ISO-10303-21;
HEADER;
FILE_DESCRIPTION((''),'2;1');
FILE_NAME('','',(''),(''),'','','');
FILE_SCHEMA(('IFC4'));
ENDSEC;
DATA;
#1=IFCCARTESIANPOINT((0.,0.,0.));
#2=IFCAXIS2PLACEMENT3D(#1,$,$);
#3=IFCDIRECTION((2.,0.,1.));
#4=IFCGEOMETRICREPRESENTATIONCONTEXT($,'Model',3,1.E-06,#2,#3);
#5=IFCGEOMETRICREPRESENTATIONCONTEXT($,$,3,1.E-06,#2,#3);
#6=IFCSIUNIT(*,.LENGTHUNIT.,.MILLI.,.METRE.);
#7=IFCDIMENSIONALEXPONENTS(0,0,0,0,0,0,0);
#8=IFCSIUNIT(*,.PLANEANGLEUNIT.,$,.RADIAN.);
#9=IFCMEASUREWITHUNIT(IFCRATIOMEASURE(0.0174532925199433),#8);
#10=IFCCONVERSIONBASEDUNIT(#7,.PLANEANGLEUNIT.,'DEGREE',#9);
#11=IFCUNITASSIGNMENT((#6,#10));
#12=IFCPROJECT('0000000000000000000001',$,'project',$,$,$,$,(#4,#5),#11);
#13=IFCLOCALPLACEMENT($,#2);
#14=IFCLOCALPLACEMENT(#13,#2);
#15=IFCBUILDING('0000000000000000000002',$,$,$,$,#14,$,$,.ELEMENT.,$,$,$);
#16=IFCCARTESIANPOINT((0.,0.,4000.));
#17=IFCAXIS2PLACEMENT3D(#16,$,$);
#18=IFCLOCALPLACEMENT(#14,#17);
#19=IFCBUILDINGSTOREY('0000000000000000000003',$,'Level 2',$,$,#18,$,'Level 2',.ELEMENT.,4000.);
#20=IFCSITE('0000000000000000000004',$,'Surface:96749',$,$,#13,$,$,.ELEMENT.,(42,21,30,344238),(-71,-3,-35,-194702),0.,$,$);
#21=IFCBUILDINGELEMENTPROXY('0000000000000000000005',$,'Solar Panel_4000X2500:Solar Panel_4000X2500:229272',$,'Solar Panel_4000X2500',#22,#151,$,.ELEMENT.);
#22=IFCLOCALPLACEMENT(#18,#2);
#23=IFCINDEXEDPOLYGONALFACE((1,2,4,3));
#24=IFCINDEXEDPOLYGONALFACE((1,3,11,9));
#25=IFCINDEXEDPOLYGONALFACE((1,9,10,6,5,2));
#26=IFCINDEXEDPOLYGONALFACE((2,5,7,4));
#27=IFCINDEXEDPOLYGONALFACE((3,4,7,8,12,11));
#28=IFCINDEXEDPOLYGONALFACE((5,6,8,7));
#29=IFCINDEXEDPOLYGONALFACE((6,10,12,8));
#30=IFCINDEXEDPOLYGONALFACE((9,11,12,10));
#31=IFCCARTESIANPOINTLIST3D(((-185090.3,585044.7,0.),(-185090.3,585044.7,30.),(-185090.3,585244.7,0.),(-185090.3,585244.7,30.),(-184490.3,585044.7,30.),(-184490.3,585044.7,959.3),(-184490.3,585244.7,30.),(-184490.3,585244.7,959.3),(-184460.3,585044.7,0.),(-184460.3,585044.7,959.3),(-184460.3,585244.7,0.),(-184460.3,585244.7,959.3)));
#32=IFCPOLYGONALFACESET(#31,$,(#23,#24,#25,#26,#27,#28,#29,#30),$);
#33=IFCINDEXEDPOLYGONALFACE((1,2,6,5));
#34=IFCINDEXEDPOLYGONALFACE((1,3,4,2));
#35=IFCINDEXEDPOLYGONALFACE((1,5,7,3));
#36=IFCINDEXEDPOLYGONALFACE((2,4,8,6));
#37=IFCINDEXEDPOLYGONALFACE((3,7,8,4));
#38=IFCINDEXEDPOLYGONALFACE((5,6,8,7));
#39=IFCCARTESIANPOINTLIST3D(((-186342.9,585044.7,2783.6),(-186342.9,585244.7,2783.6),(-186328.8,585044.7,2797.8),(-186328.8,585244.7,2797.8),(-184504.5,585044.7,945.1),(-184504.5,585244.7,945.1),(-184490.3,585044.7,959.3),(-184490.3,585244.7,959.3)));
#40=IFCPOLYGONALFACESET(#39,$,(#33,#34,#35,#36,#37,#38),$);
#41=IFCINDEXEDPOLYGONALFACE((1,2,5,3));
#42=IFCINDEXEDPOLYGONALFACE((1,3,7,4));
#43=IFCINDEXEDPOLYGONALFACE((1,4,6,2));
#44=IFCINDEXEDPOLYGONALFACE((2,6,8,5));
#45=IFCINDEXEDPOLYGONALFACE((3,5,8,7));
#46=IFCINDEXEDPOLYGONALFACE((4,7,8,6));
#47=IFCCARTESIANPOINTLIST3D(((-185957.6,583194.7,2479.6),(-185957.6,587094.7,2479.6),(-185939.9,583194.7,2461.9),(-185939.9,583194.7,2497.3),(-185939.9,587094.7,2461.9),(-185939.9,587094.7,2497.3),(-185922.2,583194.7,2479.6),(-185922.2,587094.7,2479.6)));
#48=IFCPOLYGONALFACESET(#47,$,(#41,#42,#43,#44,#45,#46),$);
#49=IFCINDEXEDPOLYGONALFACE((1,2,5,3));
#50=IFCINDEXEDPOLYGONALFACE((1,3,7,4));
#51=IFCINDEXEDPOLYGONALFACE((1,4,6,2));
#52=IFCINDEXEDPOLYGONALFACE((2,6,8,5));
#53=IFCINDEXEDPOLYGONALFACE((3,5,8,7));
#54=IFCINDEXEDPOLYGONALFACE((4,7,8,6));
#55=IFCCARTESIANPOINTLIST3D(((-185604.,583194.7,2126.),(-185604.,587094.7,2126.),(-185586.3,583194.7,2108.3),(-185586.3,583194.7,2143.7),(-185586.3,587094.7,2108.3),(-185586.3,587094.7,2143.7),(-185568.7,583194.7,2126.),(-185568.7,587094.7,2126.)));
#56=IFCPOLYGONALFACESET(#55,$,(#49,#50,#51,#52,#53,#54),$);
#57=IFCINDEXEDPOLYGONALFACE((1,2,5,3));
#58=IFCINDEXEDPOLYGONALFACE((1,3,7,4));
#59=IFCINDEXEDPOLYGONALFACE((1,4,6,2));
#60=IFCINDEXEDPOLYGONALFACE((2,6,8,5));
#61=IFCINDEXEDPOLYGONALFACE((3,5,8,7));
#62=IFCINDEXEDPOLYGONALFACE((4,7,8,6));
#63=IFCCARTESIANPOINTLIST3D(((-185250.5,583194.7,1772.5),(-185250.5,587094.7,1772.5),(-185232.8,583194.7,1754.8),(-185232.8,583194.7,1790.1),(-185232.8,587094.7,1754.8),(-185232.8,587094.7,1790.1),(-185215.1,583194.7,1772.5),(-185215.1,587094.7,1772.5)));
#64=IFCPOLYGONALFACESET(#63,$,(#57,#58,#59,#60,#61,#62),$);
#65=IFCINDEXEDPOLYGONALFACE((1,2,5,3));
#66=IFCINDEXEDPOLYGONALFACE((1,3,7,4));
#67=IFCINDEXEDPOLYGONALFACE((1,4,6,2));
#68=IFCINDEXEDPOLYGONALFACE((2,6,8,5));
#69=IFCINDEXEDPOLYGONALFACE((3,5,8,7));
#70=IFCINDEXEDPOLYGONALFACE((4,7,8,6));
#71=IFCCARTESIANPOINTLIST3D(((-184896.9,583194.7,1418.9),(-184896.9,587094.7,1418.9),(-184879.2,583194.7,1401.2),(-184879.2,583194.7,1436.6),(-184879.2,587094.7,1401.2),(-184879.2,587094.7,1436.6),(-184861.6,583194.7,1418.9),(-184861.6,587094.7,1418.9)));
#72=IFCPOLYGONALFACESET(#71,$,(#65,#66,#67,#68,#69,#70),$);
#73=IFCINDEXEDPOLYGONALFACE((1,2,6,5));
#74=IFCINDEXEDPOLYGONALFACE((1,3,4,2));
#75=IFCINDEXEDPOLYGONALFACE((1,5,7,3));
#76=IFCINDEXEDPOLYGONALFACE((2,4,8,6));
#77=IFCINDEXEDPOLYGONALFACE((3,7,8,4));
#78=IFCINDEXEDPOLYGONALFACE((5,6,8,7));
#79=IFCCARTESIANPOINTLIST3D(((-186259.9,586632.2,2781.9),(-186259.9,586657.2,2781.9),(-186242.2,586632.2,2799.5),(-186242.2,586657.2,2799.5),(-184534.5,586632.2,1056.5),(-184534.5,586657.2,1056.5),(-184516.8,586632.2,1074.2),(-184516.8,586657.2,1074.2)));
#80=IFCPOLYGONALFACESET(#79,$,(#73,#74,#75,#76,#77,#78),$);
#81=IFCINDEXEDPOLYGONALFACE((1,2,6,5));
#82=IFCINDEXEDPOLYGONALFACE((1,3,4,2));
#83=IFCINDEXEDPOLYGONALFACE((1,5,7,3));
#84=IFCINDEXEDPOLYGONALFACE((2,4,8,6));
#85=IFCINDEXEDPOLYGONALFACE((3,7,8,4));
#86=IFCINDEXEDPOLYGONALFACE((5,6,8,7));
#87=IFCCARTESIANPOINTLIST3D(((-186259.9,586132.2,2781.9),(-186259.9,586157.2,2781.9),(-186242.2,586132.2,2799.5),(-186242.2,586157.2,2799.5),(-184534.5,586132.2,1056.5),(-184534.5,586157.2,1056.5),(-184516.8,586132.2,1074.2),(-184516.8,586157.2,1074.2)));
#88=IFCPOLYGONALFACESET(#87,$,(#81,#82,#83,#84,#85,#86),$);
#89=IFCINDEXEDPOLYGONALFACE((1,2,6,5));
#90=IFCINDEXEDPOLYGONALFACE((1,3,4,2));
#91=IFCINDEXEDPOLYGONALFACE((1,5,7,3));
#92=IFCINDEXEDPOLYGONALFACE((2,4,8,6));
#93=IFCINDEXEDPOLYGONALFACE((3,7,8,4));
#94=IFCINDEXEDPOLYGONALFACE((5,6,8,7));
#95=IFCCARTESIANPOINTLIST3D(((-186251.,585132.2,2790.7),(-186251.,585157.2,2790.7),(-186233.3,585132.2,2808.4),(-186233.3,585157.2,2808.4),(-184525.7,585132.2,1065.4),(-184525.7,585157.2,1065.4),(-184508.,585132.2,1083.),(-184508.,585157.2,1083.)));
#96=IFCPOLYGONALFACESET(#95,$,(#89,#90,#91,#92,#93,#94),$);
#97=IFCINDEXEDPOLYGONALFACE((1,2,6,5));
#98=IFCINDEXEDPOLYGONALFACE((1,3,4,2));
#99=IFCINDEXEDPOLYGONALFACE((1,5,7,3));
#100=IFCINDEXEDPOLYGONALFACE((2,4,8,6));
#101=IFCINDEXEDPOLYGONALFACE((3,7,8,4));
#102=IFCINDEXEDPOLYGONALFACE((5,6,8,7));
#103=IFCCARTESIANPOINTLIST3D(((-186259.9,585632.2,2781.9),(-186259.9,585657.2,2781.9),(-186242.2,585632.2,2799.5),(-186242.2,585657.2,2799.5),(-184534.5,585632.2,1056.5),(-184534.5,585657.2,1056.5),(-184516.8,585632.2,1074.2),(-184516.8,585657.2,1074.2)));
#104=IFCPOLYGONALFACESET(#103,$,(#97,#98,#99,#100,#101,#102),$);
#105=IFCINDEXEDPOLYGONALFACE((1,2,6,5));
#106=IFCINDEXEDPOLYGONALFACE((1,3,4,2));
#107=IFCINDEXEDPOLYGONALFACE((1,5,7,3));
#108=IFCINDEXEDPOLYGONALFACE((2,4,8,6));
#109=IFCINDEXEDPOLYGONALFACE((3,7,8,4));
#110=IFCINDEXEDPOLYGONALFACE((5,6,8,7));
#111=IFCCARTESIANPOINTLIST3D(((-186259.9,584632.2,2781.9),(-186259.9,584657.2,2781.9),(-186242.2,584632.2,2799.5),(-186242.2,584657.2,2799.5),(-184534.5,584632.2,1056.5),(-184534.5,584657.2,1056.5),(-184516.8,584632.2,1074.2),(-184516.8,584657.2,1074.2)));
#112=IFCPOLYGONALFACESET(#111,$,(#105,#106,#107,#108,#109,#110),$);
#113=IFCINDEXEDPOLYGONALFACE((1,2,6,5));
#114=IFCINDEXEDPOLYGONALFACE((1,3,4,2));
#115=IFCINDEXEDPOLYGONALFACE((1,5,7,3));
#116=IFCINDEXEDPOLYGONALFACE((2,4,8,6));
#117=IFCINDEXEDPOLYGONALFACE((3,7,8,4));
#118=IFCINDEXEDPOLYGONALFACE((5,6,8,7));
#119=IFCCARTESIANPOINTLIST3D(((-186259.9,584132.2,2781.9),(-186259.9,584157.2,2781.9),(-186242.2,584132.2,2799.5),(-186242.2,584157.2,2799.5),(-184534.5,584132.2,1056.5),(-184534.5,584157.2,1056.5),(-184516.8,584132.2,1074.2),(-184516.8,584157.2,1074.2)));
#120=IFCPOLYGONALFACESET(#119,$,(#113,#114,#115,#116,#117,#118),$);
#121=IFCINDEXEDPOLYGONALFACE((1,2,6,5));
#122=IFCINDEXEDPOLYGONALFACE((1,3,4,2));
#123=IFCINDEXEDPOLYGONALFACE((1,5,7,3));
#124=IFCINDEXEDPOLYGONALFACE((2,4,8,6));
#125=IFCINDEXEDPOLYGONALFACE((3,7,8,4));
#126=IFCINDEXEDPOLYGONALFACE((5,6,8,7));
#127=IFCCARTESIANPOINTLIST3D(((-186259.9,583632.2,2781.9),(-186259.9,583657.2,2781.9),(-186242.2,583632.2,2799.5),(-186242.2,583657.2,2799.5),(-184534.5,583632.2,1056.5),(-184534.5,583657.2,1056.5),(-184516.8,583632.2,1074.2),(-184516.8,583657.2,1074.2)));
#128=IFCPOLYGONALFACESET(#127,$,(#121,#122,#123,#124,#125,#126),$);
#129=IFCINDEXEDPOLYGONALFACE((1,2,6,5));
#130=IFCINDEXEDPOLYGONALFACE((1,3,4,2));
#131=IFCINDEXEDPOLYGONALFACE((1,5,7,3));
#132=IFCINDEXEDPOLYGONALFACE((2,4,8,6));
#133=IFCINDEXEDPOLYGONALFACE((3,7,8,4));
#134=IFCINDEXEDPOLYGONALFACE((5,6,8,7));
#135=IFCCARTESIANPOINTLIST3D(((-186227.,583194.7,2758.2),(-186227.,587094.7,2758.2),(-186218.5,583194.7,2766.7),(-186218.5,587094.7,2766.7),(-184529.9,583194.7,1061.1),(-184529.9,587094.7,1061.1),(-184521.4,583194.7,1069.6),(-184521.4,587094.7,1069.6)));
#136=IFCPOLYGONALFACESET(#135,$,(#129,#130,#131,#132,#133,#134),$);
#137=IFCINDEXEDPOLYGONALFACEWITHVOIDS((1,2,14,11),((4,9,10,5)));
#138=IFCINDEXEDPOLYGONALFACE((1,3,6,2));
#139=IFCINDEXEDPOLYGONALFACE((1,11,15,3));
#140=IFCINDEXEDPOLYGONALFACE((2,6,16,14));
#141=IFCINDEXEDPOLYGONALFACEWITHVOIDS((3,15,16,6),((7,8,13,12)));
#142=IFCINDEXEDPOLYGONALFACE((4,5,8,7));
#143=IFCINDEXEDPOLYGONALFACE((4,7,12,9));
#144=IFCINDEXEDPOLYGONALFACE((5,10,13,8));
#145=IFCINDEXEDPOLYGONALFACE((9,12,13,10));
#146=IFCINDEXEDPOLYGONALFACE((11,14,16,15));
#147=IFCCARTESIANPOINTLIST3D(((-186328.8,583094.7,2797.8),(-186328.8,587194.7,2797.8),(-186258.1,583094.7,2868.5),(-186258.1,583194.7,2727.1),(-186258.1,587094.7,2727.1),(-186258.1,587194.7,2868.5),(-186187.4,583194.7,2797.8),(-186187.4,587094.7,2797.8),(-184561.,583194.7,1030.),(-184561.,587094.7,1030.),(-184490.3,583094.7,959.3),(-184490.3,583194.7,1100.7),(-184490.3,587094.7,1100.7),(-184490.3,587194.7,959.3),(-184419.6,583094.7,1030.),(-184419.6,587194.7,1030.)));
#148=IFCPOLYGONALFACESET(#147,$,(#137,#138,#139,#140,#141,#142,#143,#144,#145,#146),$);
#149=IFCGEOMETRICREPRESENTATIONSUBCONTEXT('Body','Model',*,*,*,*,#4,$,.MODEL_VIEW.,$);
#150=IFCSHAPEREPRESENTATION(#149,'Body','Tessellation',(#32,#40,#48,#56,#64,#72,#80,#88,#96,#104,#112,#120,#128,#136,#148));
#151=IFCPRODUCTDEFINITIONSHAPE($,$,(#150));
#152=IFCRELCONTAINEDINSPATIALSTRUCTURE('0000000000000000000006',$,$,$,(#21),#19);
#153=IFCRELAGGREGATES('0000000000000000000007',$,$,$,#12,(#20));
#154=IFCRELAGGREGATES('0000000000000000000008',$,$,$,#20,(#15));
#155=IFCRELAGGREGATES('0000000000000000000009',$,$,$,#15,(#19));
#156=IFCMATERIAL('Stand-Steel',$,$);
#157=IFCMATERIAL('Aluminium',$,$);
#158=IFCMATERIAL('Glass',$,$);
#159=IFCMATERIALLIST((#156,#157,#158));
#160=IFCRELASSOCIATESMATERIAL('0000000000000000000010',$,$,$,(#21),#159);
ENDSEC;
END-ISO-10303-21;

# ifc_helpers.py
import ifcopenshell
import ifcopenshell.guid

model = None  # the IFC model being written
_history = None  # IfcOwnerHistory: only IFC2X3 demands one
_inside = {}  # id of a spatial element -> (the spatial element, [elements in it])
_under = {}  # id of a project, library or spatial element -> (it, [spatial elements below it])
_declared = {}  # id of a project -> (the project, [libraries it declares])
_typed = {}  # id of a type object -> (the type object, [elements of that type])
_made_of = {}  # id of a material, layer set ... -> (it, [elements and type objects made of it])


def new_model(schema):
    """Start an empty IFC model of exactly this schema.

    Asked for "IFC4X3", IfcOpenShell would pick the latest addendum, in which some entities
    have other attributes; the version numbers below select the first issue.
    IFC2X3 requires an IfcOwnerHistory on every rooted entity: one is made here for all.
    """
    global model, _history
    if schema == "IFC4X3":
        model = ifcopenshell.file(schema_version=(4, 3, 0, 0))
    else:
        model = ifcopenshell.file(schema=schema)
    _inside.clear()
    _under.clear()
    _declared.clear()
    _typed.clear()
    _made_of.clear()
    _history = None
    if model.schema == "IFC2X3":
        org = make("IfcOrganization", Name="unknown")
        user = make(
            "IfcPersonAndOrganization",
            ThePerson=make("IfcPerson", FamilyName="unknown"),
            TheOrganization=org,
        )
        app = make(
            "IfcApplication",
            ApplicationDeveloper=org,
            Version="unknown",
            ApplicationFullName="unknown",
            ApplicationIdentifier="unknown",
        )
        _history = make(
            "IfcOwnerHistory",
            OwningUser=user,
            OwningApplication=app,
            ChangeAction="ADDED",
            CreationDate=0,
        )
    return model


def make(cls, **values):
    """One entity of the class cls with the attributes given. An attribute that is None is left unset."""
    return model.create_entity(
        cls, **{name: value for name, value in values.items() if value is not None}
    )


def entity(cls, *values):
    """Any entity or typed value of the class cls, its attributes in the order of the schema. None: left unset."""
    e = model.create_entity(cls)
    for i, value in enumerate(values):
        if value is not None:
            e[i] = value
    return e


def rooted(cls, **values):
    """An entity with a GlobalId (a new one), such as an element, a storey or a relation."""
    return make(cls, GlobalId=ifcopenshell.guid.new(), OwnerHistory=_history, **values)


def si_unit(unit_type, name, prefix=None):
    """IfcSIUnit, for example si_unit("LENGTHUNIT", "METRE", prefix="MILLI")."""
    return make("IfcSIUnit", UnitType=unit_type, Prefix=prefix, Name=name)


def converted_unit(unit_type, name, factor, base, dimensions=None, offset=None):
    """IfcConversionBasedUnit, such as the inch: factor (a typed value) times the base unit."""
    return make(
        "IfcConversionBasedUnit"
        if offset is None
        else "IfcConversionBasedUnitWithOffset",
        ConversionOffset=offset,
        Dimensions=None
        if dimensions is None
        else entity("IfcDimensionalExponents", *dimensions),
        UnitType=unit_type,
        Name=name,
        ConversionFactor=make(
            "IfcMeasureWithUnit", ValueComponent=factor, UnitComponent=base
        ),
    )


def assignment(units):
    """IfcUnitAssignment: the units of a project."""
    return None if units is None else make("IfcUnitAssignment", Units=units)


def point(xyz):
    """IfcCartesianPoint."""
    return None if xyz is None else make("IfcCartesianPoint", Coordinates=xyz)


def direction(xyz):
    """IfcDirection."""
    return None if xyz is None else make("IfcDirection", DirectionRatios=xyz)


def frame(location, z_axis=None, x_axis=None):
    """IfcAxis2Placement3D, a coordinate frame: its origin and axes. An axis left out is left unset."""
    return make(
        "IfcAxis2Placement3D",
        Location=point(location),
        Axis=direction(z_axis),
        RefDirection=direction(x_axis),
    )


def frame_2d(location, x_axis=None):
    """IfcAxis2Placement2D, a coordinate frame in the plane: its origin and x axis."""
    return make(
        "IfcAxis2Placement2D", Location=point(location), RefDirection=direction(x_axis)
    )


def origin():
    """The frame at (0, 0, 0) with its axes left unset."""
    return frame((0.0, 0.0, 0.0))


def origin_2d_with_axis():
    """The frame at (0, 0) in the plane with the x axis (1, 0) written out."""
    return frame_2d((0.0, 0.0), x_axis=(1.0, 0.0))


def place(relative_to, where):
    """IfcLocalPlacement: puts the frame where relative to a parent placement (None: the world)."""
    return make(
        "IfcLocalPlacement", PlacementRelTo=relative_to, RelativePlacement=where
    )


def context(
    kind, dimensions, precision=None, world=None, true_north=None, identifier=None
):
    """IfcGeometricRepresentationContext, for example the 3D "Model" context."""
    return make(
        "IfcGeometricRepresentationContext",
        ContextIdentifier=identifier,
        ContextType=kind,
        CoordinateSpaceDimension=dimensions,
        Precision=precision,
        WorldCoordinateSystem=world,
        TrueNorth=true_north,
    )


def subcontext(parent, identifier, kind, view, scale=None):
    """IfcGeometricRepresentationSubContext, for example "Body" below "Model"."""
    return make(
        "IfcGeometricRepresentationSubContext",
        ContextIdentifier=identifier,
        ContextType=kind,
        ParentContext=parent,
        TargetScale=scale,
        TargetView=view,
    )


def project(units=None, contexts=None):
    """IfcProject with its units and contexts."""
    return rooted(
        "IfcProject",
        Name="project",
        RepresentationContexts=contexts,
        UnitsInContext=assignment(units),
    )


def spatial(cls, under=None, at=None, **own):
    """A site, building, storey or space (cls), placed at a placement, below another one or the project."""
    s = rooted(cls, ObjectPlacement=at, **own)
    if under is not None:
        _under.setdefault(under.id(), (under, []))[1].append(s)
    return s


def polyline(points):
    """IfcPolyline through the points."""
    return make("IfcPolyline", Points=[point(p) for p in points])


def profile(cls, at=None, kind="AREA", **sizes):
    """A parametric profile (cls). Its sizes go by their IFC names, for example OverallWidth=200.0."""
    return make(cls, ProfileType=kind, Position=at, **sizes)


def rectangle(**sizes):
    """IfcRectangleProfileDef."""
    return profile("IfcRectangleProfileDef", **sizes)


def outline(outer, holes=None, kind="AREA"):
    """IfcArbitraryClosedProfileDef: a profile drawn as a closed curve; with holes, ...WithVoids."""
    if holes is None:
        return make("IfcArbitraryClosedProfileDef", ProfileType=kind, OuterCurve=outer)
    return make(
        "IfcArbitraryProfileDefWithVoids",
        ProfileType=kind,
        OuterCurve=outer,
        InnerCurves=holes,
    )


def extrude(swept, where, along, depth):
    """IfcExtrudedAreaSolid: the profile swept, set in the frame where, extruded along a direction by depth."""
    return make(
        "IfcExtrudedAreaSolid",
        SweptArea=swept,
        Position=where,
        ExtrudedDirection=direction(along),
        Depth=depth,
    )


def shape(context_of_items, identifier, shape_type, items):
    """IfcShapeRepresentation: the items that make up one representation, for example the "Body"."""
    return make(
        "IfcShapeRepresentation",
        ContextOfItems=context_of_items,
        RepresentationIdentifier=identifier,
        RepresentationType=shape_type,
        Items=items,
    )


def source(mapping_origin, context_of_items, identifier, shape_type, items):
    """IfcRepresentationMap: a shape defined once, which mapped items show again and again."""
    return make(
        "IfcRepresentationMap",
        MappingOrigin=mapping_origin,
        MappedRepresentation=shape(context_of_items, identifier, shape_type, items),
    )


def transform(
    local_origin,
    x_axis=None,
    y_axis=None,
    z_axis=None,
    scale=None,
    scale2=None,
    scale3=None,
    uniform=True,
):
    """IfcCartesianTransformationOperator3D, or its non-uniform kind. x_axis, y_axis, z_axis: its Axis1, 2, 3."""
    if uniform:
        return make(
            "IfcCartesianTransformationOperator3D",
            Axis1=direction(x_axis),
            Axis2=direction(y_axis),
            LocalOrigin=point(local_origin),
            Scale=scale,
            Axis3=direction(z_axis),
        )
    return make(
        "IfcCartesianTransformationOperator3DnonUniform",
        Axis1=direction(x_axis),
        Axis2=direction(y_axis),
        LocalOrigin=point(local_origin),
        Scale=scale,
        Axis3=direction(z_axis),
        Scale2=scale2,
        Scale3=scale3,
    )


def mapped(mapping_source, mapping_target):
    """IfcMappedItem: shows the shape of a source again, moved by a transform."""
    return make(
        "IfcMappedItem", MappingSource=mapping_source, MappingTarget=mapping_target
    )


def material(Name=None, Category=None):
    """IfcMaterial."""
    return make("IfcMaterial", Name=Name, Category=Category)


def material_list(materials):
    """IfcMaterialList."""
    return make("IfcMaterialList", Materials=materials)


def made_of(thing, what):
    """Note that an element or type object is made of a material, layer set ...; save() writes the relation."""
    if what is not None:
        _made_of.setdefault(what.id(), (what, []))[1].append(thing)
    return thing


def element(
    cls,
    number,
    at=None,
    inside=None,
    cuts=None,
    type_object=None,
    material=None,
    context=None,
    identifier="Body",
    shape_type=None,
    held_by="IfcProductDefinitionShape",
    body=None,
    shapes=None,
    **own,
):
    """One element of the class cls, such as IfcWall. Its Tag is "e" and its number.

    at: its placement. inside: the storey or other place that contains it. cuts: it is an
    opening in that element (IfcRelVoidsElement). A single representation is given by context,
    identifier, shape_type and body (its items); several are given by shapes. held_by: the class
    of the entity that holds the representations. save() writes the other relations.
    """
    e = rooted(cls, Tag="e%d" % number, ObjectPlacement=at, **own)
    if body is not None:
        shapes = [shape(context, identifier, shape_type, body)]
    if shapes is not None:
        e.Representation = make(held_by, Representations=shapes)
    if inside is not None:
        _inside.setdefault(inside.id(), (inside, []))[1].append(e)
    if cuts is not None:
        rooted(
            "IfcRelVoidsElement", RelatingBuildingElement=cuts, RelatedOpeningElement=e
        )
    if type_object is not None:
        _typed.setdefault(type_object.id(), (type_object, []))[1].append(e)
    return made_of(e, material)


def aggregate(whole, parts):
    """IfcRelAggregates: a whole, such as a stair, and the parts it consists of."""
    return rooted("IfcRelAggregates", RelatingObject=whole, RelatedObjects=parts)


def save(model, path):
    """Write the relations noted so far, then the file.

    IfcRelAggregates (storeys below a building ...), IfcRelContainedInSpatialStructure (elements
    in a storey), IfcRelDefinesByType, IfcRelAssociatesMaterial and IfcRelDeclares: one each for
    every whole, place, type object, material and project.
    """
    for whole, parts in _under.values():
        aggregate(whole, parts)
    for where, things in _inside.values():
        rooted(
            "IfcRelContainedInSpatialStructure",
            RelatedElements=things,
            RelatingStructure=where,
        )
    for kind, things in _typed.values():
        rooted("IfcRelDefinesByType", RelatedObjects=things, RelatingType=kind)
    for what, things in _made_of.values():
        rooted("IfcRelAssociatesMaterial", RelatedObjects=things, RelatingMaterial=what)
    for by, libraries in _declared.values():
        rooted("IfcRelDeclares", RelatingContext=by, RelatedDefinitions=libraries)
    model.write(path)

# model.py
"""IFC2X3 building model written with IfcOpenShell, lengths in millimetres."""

from ifc_helpers import new_model, entity, si_unit, converted_unit, direction, frame, frame_2d, origin, origin_2d_with_axis, place, context, subcontext, project, spatial, polyline, rectangle, outline, extrude, source, transform, mapped, material, material_list, element, save


model = new_model("IFC2X3")

# Units and contexts
model_context = context("Model", 3, precision=1e-06, world=origin(), true_north=direction((2.0, 0.0, 1.0)))
context_of_model = context(None, 3, precision=1e-06, world=origin(), true_north=direction((2.0, 0.0, 1.0)))
body_context = subcontext(model_context, "Body", "Model", "MODEL_VIEW")
ifc_project = project(units=[si_unit("LENGTHUNIT", "METRE", prefix="MILLI"), converted_unit("PLANEANGLEUNIT", "DEGREE", entity("IfcRatioMeasure", 0.0174532925199433), si_unit("PLANEANGLEUNIT", "RADIAN"), dimensions=[0, 0, 0, 0, 0, 0, 0])], contexts=[model_context, context_of_model])

# Site, building, storey
site_placement = place(None, origin())
site = spatial("IfcSite", under=ifc_project, at=site_placement, Name="Surface:96749", CompositionType="ELEMENT", RefLatitude=(42, 21, 30, 344238), RefLongitude=(-71, -3, -35, -194702), RefElevation=0.0)
building_placement = place(site_placement, origin())
building = spatial("IfcBuilding", under=site, at=building_placement, CompositionType="ELEMENT")
storey_placement = place(building_placement, frame((0.0, 0.0, 4000.0)))
storey = spatial("IfcBuildingStorey", under=building, at=storey_placement, Name="Level 2", LongName="Level 2", CompositionType="ELEMENT", Elevation=4000.0)

# Building element proxy
ifc_material_1 = material(Name="Stand-Steel")
ifc_material_2 = material(Name="Aluminium")
ifc_material_3 = material(Name="Glass")
shared_shape = source(origin(), body_context, "Body", "SweptSolid", [
    extrude(outline(polyline([(-629.5, -220.0), (329.8, -220.0), (329.8, 410.0), (299.8, 410.0), (299.8, -190.0), (-629.5, -190.0), (-629.5, -220.0)])), frame((-190.0, -100.0, 299.8), z_axis=(0.0, 1.0, 0.0), x_axis=(0.0, 0.0, -1.0)), (0.0, 0.0, 1.0), 200.0),
    extrude(rectangle(XDim=20.0, YDim=200.0, at=frame_2d((0.0, 0.0), x_axis=(0.0, 1.0))), frame((-7.1, 0.0, 922.2), z_axis=(-0.707107, 0.0, 0.707107), x_axis=(0.0, 1.0, 0.0)), (0.0, 0.0, 1.0), 2600.0),
    extrude(rectangle(XDim=25.0, YDim=25.0, at=frame_2d((0.0, 0.0), x_axis=(1.0, 0.0))), frame((-1449.6, -1950.0, 2449.6), z_axis=(0.0, 1.0, 0.0), x_axis=(-0.707107, 0.0, -0.707107)), (0.0, 0.0, 1.0), 3900.0),
    extrude(rectangle(XDim=25.0, YDim=25.0, at=origin_2d_with_axis()), frame((-1096.0, -1950.0, 2096.0), z_axis=(0.0, 1.0, 0.0), x_axis=(-0.707107, 0.0, -0.707107)), (0.0, 0.0, 1.0), 3900.0),
    extrude(rectangle(XDim=25.0, YDim=25.0, at=origin_2d_with_axis()), frame((-742.5, -1950.0, 1742.5), z_axis=(0.0, 1.0, 0.0), x_axis=(-0.707107, 0.0, -0.707107)), (0.0, 0.0, 1.0), 3900.0),
    extrude(rectangle(XDim=25.0, YDim=25.0, at=frame_2d((0.0, 0.0), x_axis=(1.0, 0.0))), frame((-388.9, -1950.0, 1388.9), z_axis=(0.0, 1.0, 0.0), x_axis=(-0.707107, 0.0, -0.707107)), (0.0, 0.0, 1.0), 3900.0),
    extrude(rectangle(XDim=25.0, YDim=25.0, at=frame_2d((0.0, 0.0), x_axis=(0.0, 1.0))), frame((-35.4, 1500.0, 1035.4), z_axis=(-0.707107, 0.0, 0.707107), x_axis=(0.0, 1.0, 0.0)), (0.0, 0.0, 1.0), 2440.0),
    extrude(rectangle(XDim=25.0, YDim=25.0, at=frame_2d((0.0, 0.0), x_axis=(0.0, 1.0))), frame((-35.4, 1000.0, 1035.4), z_axis=(-0.707107, 0.0, 0.707107), x_axis=(0.0, 1.0, 0.0)), (0.0, 0.0, 1.0), 2440.0),
    extrude(rectangle(XDim=25.0, YDim=25.0, at=frame_2d((0.0, 0.0), x_axis=(0.0, 1.0))), frame((-26.5, 0.0, 1044.2), z_axis=(-0.707107, 0.0, 0.707107), x_axis=(0.0, -1.0, 0.0)), (0.0, 0.0, 1.0), 2440.0),
    extrude(rectangle(XDim=25.0, YDim=25.0, at=frame_2d((0.0, 0.0), x_axis=(0.0, 1.0))), frame((-35.4, 500.0, 1035.4), z_axis=(-0.707107, 0.0, 0.707107), x_axis=(0.0, 1.0, 0.0)), (0.0, 0.0, 1.0), 2440.0),
    extrude(rectangle(XDim=25.0, YDim=25.0, at=frame_2d((0.0, 0.0), x_axis=(0.0, 1.0))), frame((-35.4, -500.0, 1035.4), z_axis=(-0.707107, 0.0, 0.707107), x_axis=(0.0, 1.0, 0.0)), (0.0, 0.0, 1.0), 2440.0),
    extrude(rectangle(XDim=25.0, YDim=25.0, at=frame_2d((0.0, 0.0), x_axis=(0.0, 1.0))), frame((-35.4, -1000.0, 1035.4), z_axis=(-0.707107, 0.0, 0.707107), x_axis=(0.0, 1.0, 0.0)), (0.0, 0.0, 1.0), 2440.0),
    extrude(rectangle(XDim=25.0, YDim=25.0, at=frame_2d((0.0, 0.0), x_axis=(0.0, 1.0))), frame((-35.4, -1500.0, 1035.4), z_axis=(-0.707107, 0.0, 0.707107), x_axis=(0.0, 1.0, 0.0)), (0.0, 0.0, 1.0), 2440.0),
    extrude(rectangle(XDim=2400.0, YDim=12.0, at=frame_2d((0.0, 0.0), x_axis=(1.0, 0.0))), frame((-883.9, -1950.0, 1883.9), z_axis=(0.0, 1.0, 0.0), x_axis=(0.707107, 0.0, -0.707107)), (0.0, 0.0, 1.0), 3900.0),
    extrude(outline(polyline([(-2050.0, -1300.0), (2050.0, -1300.0), (2050.0, 1300.0), (-2050.0, 1300.0), (-2050.0, -1300.0)]), holes=[polyline([(1950.0, -1200.0), (-1950.0, -1200.0), (-1950.0, 1200.0), (1950.0, 1200.0), (1950.0, -1200.0)])]), frame((-919.2, 0.0, 1848.5), z_axis=(0.707107, 0.0, 0.707107), x_axis=(0.0, 1.0, 0.0)), (0.0, 0.0, 1.0), 100.0),
])
ifc_material_list_1 = material_list([ifc_material_1, ifc_material_2, ifc_material_3])
proxy_1_placement = place(storey_placement, frame((-184490.3, 585144.7, 30.0)))
element("IfcBuildingElementProxy", 1, at=proxy_1_placement, inside=storey, material=ifc_material_list_1, Name="Solar Panel_4000X2500:Solar Panel_4000X2500:229272", ObjectType="Solar Panel_4000X2500", CompositionType="ELEMENT", context=body_context, shape_type="MappedRepresentation", body=[
    mapped(shared_shape, transform((0.0, 0.0, 0.0), scale=1.0)),
])

save(model, "model.ifc")
